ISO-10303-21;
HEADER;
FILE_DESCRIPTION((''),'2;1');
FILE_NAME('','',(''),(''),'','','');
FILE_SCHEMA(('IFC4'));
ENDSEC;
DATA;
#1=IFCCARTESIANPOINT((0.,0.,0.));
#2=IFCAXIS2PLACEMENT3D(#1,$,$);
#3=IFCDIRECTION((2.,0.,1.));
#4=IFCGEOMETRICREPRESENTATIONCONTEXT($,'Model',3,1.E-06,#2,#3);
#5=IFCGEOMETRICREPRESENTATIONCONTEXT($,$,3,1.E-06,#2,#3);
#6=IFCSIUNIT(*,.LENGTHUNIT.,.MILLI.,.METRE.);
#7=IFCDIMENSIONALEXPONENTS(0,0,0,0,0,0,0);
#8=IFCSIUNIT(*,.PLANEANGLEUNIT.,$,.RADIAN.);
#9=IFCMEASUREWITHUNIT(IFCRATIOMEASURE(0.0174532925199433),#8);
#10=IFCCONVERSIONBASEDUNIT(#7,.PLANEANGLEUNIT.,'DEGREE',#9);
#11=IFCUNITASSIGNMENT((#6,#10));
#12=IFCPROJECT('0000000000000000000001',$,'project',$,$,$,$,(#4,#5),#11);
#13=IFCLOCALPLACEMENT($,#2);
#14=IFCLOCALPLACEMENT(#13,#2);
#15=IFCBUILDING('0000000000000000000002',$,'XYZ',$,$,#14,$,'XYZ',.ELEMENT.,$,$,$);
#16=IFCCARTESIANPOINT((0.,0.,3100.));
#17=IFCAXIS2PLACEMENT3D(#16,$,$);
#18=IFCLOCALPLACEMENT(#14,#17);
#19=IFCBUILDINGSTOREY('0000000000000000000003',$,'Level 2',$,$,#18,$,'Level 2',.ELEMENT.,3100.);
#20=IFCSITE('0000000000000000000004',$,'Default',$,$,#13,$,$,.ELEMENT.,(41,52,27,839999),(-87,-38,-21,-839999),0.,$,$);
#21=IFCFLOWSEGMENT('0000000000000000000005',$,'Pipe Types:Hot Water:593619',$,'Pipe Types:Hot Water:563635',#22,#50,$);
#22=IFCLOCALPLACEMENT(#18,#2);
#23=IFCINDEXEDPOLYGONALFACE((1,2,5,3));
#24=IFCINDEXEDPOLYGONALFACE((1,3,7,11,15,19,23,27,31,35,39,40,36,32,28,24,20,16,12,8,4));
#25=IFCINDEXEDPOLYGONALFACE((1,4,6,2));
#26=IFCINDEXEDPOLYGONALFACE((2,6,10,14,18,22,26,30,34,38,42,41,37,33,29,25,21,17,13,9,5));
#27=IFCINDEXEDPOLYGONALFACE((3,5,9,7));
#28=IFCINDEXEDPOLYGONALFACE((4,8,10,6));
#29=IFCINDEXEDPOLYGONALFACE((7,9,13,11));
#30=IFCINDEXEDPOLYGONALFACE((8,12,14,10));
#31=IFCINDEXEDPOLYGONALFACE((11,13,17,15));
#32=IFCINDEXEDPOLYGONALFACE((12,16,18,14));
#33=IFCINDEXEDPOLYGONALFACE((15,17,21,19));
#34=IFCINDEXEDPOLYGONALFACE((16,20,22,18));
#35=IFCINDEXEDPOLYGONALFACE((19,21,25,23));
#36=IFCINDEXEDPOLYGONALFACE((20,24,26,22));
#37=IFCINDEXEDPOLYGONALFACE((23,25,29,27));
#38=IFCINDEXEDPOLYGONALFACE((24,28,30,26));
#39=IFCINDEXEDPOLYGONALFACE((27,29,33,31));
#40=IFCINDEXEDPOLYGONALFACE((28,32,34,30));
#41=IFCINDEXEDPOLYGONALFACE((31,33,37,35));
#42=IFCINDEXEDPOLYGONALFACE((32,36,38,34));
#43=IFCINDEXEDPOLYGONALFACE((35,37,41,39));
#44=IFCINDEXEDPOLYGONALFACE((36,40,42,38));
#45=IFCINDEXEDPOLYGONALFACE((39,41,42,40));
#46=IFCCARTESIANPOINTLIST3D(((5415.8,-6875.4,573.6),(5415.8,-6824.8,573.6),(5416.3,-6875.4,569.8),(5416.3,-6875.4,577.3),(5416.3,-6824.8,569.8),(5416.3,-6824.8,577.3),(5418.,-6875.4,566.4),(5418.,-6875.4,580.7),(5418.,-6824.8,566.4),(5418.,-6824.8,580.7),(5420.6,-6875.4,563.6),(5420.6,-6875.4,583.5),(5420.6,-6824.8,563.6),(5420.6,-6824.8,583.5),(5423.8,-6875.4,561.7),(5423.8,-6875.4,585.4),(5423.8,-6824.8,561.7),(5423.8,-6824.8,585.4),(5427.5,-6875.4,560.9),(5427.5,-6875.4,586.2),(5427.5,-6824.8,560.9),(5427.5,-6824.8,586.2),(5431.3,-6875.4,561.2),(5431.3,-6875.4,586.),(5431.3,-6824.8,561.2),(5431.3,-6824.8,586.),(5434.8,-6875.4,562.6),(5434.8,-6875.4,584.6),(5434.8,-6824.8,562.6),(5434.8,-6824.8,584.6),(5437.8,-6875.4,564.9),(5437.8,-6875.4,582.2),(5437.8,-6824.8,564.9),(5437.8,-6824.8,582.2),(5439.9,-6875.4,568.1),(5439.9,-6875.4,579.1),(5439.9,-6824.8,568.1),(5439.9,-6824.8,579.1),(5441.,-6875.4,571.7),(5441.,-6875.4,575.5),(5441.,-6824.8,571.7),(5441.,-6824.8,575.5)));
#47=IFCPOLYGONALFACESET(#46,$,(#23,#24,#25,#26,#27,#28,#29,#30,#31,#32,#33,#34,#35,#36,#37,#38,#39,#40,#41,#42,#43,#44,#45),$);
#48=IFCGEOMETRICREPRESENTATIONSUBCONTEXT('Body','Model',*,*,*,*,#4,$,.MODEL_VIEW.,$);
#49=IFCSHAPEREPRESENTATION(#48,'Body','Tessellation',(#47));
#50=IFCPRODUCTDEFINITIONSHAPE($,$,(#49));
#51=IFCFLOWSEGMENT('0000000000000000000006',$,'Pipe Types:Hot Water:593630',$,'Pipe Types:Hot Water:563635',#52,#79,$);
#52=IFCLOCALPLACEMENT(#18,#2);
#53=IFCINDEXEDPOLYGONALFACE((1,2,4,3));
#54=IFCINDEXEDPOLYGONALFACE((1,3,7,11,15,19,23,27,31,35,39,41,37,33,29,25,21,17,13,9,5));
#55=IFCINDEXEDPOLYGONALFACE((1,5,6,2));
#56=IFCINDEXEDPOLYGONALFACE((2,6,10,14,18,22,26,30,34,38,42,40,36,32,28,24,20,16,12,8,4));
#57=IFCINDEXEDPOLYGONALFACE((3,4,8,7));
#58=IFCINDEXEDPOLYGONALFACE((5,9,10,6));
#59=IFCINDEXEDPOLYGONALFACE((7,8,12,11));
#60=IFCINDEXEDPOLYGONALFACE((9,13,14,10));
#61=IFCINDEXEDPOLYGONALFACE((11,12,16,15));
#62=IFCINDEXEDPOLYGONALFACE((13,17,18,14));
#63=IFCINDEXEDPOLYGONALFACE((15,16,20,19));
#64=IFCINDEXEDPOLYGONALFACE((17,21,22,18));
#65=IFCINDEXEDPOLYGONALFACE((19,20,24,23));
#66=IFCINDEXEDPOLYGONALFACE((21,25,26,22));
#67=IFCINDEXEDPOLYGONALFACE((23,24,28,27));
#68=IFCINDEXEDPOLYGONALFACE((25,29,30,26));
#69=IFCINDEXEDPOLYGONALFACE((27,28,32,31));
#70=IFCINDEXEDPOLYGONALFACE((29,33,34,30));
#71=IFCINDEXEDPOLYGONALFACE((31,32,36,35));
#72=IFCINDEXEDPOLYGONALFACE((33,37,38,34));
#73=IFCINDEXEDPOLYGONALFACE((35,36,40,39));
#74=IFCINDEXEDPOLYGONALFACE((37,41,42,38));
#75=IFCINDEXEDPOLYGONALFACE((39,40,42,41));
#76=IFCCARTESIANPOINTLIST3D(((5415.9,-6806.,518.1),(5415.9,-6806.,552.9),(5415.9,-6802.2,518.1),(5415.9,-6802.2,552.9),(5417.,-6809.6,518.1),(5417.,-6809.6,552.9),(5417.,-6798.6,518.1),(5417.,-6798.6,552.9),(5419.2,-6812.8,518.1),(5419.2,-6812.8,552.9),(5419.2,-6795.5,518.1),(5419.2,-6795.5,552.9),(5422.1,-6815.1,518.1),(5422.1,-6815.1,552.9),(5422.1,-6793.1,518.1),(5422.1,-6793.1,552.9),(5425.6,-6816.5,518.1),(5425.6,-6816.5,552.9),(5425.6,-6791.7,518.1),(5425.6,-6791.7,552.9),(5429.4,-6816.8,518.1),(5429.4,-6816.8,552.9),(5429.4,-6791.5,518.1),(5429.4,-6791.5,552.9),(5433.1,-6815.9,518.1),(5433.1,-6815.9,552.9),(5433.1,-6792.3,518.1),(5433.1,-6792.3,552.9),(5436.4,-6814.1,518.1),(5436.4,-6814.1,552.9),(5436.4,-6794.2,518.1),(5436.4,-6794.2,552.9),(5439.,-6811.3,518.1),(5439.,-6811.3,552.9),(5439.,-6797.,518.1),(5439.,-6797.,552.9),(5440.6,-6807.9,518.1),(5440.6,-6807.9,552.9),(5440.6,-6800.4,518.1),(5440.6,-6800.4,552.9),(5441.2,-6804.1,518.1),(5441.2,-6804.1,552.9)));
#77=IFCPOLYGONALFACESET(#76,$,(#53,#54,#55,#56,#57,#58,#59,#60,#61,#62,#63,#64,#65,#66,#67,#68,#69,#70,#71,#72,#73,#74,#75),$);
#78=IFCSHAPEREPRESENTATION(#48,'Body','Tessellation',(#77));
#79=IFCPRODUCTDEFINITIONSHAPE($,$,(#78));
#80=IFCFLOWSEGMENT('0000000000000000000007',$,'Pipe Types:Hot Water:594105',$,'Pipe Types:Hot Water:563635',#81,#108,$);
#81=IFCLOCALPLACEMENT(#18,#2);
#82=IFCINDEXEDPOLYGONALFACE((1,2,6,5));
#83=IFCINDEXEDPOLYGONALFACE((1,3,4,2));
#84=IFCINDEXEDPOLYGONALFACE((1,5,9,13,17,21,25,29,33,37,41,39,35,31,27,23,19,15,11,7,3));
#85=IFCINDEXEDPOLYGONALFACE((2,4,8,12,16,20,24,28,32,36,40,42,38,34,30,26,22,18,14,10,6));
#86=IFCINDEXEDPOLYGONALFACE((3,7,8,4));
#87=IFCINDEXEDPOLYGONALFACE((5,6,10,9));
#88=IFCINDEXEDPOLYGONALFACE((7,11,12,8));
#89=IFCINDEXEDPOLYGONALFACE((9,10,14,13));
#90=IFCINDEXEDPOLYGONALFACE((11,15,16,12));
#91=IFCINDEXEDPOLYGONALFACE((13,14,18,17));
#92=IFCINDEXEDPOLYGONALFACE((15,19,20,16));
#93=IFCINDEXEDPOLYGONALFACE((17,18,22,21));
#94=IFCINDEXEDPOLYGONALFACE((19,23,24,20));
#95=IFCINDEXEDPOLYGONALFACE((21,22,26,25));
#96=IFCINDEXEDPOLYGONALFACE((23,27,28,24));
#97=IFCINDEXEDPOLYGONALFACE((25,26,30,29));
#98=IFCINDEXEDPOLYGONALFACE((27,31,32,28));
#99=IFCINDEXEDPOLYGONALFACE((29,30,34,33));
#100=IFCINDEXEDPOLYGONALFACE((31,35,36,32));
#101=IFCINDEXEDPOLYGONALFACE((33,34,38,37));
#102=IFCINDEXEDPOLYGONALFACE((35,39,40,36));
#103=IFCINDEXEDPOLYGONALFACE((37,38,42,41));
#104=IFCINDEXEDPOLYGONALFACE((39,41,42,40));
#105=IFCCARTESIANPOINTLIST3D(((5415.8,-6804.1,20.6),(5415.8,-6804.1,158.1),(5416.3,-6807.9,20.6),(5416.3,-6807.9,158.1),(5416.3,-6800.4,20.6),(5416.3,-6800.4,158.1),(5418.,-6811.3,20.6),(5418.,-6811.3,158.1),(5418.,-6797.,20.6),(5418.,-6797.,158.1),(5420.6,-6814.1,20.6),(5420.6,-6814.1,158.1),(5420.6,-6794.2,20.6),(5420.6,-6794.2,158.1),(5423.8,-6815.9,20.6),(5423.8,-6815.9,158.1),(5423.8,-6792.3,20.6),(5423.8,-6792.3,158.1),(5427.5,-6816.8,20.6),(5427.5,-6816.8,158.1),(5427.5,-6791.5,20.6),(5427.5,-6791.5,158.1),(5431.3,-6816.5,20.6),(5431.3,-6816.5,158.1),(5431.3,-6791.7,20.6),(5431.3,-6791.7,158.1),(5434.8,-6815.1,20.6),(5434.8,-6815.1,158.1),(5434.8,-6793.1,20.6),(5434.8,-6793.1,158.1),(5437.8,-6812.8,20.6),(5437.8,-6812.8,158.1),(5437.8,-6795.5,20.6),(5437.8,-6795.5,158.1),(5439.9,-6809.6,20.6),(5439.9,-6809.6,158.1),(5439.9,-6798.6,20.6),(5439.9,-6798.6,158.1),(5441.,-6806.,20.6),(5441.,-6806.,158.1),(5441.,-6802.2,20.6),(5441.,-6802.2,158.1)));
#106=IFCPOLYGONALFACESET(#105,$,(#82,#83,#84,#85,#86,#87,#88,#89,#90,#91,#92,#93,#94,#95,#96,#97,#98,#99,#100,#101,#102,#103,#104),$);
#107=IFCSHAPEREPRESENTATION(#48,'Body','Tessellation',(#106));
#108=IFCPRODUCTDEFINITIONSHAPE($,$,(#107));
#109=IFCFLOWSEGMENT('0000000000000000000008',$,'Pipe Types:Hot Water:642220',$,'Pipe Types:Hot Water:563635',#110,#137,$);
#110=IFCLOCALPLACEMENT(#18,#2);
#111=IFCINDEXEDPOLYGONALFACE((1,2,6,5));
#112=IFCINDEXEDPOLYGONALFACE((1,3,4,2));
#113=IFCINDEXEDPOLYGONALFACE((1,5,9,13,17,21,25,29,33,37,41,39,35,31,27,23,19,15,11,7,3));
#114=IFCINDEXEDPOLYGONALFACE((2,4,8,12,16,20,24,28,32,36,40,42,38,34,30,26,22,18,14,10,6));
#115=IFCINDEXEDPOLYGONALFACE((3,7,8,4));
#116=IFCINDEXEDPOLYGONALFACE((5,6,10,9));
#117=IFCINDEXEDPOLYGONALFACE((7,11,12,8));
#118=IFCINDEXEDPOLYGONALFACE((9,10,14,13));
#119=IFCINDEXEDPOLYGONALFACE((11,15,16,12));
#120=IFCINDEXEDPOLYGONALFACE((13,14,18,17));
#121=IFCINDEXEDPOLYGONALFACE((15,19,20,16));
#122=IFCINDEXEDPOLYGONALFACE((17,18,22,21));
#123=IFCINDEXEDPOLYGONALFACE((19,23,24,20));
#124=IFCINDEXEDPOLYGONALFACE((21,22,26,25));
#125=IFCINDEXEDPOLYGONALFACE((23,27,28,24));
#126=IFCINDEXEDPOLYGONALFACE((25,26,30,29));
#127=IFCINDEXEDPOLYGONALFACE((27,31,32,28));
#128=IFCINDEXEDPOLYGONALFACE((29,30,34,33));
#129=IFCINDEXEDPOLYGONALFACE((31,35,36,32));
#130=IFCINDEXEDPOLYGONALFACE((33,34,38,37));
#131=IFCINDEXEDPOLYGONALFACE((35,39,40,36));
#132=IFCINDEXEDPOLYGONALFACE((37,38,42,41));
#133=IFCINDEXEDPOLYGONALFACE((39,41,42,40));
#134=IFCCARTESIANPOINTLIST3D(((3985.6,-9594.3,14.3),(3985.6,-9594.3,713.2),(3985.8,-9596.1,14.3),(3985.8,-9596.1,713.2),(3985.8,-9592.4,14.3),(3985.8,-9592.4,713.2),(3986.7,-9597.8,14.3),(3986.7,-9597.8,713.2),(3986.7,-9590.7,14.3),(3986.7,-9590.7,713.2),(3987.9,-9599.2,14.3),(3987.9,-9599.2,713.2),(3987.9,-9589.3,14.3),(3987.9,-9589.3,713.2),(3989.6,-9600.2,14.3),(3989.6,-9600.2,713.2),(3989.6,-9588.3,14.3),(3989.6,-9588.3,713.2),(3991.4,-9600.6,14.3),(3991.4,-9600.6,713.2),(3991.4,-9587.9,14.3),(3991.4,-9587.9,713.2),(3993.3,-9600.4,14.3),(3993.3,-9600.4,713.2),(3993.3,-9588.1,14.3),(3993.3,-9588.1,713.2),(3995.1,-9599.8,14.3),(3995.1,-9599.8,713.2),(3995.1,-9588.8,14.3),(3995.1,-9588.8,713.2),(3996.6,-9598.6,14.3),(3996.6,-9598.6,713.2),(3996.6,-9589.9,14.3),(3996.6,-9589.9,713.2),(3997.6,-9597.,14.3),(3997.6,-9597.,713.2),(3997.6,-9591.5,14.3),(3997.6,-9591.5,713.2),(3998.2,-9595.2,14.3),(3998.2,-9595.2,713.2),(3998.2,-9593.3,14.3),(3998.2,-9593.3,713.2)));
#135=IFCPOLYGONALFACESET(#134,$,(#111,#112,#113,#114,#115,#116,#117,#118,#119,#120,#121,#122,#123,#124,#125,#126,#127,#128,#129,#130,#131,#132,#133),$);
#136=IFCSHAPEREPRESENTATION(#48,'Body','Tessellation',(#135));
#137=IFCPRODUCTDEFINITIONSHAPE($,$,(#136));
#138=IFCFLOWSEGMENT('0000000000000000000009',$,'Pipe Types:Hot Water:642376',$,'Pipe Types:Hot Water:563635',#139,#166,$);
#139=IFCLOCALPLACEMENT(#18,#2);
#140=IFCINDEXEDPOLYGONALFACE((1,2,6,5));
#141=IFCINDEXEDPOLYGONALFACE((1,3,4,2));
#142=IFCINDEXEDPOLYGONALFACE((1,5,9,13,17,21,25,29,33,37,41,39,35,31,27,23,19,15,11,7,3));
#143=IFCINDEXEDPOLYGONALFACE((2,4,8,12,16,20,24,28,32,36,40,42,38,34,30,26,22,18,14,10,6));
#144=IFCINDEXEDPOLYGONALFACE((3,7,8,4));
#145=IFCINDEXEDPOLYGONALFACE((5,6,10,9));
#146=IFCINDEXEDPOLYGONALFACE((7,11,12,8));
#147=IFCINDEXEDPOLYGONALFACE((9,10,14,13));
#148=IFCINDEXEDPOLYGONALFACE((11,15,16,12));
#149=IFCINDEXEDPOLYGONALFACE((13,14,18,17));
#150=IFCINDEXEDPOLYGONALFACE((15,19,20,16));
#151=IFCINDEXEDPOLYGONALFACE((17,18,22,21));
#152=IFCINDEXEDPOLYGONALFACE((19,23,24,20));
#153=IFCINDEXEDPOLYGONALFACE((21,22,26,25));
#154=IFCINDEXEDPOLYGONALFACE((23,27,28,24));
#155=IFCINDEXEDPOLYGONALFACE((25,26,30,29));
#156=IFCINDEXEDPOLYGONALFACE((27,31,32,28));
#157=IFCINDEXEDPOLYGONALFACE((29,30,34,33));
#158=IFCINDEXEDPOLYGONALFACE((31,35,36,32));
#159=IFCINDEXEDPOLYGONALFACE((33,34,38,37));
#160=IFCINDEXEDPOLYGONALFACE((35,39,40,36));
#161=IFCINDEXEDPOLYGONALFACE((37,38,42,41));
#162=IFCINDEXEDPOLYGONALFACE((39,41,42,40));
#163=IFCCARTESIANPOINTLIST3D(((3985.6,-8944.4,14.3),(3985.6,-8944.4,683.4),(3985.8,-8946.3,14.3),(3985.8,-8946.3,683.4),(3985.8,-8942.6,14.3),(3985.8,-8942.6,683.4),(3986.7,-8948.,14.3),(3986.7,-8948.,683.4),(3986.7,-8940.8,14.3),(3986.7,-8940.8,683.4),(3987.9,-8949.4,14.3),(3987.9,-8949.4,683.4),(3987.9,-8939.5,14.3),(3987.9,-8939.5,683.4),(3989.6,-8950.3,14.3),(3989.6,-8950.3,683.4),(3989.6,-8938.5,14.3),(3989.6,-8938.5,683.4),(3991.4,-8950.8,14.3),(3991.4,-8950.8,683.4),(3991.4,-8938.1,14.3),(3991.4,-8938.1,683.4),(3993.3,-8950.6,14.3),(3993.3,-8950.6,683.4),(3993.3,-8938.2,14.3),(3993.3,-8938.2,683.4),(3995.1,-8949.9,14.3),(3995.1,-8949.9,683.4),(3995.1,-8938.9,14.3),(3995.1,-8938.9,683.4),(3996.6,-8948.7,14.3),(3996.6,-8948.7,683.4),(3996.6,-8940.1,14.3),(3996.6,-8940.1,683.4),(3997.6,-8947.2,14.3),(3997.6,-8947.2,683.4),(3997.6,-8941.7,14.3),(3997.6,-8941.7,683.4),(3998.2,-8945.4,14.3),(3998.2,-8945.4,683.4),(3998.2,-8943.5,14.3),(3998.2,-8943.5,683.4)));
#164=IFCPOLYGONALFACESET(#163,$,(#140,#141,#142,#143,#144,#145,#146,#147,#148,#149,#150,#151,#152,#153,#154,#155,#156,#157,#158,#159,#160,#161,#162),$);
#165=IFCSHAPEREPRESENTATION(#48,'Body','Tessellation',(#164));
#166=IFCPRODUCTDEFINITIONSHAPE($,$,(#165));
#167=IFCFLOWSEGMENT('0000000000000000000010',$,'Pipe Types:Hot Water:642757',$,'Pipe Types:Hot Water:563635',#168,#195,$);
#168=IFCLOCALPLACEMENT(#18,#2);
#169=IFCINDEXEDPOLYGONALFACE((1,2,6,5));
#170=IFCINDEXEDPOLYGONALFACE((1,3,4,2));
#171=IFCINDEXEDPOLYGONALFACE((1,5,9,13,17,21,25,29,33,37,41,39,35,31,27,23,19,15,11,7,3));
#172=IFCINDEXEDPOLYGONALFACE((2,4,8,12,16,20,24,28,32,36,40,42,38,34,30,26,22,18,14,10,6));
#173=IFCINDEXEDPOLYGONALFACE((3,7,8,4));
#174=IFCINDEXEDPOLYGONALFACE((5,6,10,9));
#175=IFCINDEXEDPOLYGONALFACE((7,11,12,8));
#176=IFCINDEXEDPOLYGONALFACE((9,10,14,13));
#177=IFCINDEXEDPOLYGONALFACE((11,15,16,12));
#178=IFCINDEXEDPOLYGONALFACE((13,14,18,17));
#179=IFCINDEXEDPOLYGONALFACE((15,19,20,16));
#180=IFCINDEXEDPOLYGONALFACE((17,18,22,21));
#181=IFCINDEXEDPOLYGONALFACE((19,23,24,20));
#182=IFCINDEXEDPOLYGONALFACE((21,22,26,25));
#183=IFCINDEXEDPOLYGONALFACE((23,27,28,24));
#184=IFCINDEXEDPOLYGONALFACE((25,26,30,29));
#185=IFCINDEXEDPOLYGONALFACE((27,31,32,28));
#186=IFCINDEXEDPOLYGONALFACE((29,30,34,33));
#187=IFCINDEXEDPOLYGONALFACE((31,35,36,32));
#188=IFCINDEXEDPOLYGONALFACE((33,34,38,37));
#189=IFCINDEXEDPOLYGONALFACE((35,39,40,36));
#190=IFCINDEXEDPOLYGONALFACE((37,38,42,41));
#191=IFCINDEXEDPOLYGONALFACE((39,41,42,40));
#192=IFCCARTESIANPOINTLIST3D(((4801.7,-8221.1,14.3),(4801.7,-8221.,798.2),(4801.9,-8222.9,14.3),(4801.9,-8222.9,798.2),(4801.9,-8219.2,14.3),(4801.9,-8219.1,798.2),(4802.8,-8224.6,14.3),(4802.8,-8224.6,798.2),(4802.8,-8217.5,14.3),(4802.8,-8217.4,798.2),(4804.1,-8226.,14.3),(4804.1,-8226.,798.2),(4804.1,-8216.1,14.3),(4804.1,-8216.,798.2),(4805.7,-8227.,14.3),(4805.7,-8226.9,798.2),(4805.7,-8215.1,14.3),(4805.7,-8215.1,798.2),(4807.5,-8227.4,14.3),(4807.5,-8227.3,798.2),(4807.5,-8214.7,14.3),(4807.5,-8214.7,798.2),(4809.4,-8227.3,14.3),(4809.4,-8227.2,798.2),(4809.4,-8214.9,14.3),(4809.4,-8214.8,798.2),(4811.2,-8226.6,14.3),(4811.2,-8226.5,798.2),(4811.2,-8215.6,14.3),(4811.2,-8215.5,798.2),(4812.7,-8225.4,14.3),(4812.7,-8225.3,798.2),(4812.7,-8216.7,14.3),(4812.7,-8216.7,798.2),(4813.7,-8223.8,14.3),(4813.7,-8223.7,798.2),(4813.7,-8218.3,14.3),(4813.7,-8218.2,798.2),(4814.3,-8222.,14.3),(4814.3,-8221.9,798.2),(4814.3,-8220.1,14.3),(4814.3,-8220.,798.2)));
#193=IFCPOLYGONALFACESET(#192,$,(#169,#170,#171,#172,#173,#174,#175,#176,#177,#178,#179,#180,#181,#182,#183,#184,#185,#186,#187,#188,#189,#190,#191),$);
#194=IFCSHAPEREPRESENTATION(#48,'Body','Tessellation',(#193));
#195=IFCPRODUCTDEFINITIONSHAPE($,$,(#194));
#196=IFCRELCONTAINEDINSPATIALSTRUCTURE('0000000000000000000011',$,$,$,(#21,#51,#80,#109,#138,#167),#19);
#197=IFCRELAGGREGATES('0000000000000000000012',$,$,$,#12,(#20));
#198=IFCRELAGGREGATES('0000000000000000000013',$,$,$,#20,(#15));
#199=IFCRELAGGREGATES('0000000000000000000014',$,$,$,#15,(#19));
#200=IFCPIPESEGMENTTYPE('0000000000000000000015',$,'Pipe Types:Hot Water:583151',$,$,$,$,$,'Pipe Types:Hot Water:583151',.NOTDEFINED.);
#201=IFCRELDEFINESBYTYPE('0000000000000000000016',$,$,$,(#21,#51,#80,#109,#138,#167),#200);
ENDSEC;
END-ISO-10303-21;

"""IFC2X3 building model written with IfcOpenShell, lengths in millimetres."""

from ifc_helpers import new_model, entity, si_unit, converted_unit, direction, frame, frame_2d, origin, origin_2d_with_axis, place, context, subcontext, project, spatial, circle, extrude, type_object, element, save


model = new_model("IFC2X3")

# Units and contexts
model_context = context("Model", 3, precision=1e-06, world=origin(), true_north=direction((2.0, 0.0, 1.0)))
context_of_model = context(None, 3, precision=1e-06, world=origin(), true_north=direction((2.0, 0.0, 1.0)))
body_context = subcontext(model_context, "Body", "Model", "MODEL_VIEW")
ifc_project = project(units=[si_unit("LENGTHUNIT", "METRE", prefix="MILLI"), converted_unit("PLANEANGLEUNIT", "DEGREE", entity("IfcRatioMeasure", 0.0174532925199433), si_unit("PLANEANGLEUNIT", "RADIAN"), dimensions=[0, 0, 0, 0, 0, 0, 0])], contexts=[model_context, context_of_model])

# Site, building, storey
site_placement = place(None, origin())
site = spatial("IfcSite", under=ifc_project, at=site_placement, Name="Default", CompositionType="ELEMENT", RefLatitude=(41, 52, 27, 839999), RefLongitude=(-87, -38, -21, -839999), RefElevation=0.0)
building_placement = place(site_placement, origin())
building = spatial("IfcBuilding", under=site, at=building_placement, Name="XYZ", LongName="XYZ", CompositionType="ELEMENT")
storey_placement = place(building_placement, frame((0.0, 0.0, 3100.0)))
storey = spatial("IfcBuildingStorey", under=building, at=storey_placement, Name="Level 2", LongName="Level 2", CompositionType="ELEMENT", Elevation=3100.0)

# Flow segments
pipe_segment_type_1 = type_object("IfcPipeSegmentType", Name="Pipe Types:Hot Water:583151", ElementType="Pipe Types:Hot Water:583151", PredefinedType="NOTDEFINED")
flow_segment_1_placement = place(storey_placement, origin())
element("IfcFlowSegment", 1, at=flow_segment_1_placement, inside=storey, type_object=pipe_segment_type_1, Name="Pipe Types:Hot Water:593619", ObjectType="Pipe Types:Hot Water:563635", context=body_context, shape_type="SweptSolid", body=[
    extrude(circle(Radius=12.7, at=frame_2d((0.0, 0.0), x_axis=(1.0, 0.0))), frame((5428.5, -6875.4, 573.6), z_axis=(0.0, 1.0, 0.0), x_axis=(-1.0, 0.0, 0.0)), (0.0, 0.0, 1.0), 50.6),
])
flow_segment_2_placement = place(storey_placement, origin())
element("IfcFlowSegment", 2, at=flow_segment_2_placement, inside=storey, type_object=pipe_segment_type_1, Name="Pipe Types:Hot Water:593630", ObjectType="Pipe Types:Hot Water:563635", context=body_context, shape_type="SweptSolid", body=[
    extrude(circle(Radius=12.7, at=origin_2d_with_axis()), frame((5428.5, -6804.1, 518.1)), (0.0, 0.0, 1.0), 34.9),
])
flow_segment_3_placement = place(storey_placement, origin())
element("IfcFlowSegment", 3, at=flow_segment_3_placement, inside=storey, type_object=pipe_segment_type_1, Name="Pipe Types:Hot Water:594105", ObjectType="Pipe Types:Hot Water:563635", context=body_context, shape_type="SweptSolid", body=[
    extrude(circle(Radius=12.7, at=origin_2d_with_axis()), frame((5428.5, -6804.1, 20.6), z_axis=(0.0, 0.0, 1.0), x_axis=(-1.0, 0.0, 0.0)), (0.0, 0.0, 1.0), 137.4),
])
flow_segment_4_placement = place(storey_placement, origin())
element("IfcFlowSegment", 4, at=flow_segment_4_placement, inside=storey, type_object=pipe_segment_type_1, Name="Pipe Types:Hot Water:642220", ObjectType="Pipe Types:Hot Water:563635", context=body_context, shape_type="SweptSolid", body=[
    extrude(circle(Radius=6.3, at=origin_2d_with_axis()), frame((3991.9, -9594.3, 14.3), z_axis=(0.0, 0.0, 1.0), x_axis=(-1.0, 0.0, 0.0)), (0.0, 0.0, 1.0), 698.9),
])
flow_segment_5_placement = place(storey_placement, origin())
element("IfcFlowSegment", 5, at=flow_segment_5_placement, inside=storey, type_object=pipe_segment_type_1, Name="Pipe Types:Hot Water:642376", ObjectType="Pipe Types:Hot Water:563635", context=body_context, shape_type="SweptSolid", body=[
    extrude(circle(Radius=6.3, at=origin_2d_with_axis()), frame((3991.9, -8944.4, 14.3), z_axis=(0.0, 0.0, 1.0), x_axis=(-1.0, 0.0, 0.0)), (0.0, 0.0, 1.0), 669.1),
])
flow_segment_6_placement = place(storey_placement, origin())
element("IfcFlowSegment", 6, at=flow_segment_6_placement, inside=storey, type_object=pipe_segment_type_1, Name="Pipe Types:Hot Water:642757", ObjectType="Pipe Types:Hot Water:563635", context=body_context, shape_type="SweptSolid", body=[
    extrude(circle(Radius=6.3, at=origin_2d_with_axis()), frame((4808.0, -8221.1, 14.3), z_axis=(0.0, 0.000095, 1.0), x_axis=(-1.0, 0.0, 0.0)), (0.0, 0.0, 1.0), 783.9),
])

save(model, "model.ifc")
